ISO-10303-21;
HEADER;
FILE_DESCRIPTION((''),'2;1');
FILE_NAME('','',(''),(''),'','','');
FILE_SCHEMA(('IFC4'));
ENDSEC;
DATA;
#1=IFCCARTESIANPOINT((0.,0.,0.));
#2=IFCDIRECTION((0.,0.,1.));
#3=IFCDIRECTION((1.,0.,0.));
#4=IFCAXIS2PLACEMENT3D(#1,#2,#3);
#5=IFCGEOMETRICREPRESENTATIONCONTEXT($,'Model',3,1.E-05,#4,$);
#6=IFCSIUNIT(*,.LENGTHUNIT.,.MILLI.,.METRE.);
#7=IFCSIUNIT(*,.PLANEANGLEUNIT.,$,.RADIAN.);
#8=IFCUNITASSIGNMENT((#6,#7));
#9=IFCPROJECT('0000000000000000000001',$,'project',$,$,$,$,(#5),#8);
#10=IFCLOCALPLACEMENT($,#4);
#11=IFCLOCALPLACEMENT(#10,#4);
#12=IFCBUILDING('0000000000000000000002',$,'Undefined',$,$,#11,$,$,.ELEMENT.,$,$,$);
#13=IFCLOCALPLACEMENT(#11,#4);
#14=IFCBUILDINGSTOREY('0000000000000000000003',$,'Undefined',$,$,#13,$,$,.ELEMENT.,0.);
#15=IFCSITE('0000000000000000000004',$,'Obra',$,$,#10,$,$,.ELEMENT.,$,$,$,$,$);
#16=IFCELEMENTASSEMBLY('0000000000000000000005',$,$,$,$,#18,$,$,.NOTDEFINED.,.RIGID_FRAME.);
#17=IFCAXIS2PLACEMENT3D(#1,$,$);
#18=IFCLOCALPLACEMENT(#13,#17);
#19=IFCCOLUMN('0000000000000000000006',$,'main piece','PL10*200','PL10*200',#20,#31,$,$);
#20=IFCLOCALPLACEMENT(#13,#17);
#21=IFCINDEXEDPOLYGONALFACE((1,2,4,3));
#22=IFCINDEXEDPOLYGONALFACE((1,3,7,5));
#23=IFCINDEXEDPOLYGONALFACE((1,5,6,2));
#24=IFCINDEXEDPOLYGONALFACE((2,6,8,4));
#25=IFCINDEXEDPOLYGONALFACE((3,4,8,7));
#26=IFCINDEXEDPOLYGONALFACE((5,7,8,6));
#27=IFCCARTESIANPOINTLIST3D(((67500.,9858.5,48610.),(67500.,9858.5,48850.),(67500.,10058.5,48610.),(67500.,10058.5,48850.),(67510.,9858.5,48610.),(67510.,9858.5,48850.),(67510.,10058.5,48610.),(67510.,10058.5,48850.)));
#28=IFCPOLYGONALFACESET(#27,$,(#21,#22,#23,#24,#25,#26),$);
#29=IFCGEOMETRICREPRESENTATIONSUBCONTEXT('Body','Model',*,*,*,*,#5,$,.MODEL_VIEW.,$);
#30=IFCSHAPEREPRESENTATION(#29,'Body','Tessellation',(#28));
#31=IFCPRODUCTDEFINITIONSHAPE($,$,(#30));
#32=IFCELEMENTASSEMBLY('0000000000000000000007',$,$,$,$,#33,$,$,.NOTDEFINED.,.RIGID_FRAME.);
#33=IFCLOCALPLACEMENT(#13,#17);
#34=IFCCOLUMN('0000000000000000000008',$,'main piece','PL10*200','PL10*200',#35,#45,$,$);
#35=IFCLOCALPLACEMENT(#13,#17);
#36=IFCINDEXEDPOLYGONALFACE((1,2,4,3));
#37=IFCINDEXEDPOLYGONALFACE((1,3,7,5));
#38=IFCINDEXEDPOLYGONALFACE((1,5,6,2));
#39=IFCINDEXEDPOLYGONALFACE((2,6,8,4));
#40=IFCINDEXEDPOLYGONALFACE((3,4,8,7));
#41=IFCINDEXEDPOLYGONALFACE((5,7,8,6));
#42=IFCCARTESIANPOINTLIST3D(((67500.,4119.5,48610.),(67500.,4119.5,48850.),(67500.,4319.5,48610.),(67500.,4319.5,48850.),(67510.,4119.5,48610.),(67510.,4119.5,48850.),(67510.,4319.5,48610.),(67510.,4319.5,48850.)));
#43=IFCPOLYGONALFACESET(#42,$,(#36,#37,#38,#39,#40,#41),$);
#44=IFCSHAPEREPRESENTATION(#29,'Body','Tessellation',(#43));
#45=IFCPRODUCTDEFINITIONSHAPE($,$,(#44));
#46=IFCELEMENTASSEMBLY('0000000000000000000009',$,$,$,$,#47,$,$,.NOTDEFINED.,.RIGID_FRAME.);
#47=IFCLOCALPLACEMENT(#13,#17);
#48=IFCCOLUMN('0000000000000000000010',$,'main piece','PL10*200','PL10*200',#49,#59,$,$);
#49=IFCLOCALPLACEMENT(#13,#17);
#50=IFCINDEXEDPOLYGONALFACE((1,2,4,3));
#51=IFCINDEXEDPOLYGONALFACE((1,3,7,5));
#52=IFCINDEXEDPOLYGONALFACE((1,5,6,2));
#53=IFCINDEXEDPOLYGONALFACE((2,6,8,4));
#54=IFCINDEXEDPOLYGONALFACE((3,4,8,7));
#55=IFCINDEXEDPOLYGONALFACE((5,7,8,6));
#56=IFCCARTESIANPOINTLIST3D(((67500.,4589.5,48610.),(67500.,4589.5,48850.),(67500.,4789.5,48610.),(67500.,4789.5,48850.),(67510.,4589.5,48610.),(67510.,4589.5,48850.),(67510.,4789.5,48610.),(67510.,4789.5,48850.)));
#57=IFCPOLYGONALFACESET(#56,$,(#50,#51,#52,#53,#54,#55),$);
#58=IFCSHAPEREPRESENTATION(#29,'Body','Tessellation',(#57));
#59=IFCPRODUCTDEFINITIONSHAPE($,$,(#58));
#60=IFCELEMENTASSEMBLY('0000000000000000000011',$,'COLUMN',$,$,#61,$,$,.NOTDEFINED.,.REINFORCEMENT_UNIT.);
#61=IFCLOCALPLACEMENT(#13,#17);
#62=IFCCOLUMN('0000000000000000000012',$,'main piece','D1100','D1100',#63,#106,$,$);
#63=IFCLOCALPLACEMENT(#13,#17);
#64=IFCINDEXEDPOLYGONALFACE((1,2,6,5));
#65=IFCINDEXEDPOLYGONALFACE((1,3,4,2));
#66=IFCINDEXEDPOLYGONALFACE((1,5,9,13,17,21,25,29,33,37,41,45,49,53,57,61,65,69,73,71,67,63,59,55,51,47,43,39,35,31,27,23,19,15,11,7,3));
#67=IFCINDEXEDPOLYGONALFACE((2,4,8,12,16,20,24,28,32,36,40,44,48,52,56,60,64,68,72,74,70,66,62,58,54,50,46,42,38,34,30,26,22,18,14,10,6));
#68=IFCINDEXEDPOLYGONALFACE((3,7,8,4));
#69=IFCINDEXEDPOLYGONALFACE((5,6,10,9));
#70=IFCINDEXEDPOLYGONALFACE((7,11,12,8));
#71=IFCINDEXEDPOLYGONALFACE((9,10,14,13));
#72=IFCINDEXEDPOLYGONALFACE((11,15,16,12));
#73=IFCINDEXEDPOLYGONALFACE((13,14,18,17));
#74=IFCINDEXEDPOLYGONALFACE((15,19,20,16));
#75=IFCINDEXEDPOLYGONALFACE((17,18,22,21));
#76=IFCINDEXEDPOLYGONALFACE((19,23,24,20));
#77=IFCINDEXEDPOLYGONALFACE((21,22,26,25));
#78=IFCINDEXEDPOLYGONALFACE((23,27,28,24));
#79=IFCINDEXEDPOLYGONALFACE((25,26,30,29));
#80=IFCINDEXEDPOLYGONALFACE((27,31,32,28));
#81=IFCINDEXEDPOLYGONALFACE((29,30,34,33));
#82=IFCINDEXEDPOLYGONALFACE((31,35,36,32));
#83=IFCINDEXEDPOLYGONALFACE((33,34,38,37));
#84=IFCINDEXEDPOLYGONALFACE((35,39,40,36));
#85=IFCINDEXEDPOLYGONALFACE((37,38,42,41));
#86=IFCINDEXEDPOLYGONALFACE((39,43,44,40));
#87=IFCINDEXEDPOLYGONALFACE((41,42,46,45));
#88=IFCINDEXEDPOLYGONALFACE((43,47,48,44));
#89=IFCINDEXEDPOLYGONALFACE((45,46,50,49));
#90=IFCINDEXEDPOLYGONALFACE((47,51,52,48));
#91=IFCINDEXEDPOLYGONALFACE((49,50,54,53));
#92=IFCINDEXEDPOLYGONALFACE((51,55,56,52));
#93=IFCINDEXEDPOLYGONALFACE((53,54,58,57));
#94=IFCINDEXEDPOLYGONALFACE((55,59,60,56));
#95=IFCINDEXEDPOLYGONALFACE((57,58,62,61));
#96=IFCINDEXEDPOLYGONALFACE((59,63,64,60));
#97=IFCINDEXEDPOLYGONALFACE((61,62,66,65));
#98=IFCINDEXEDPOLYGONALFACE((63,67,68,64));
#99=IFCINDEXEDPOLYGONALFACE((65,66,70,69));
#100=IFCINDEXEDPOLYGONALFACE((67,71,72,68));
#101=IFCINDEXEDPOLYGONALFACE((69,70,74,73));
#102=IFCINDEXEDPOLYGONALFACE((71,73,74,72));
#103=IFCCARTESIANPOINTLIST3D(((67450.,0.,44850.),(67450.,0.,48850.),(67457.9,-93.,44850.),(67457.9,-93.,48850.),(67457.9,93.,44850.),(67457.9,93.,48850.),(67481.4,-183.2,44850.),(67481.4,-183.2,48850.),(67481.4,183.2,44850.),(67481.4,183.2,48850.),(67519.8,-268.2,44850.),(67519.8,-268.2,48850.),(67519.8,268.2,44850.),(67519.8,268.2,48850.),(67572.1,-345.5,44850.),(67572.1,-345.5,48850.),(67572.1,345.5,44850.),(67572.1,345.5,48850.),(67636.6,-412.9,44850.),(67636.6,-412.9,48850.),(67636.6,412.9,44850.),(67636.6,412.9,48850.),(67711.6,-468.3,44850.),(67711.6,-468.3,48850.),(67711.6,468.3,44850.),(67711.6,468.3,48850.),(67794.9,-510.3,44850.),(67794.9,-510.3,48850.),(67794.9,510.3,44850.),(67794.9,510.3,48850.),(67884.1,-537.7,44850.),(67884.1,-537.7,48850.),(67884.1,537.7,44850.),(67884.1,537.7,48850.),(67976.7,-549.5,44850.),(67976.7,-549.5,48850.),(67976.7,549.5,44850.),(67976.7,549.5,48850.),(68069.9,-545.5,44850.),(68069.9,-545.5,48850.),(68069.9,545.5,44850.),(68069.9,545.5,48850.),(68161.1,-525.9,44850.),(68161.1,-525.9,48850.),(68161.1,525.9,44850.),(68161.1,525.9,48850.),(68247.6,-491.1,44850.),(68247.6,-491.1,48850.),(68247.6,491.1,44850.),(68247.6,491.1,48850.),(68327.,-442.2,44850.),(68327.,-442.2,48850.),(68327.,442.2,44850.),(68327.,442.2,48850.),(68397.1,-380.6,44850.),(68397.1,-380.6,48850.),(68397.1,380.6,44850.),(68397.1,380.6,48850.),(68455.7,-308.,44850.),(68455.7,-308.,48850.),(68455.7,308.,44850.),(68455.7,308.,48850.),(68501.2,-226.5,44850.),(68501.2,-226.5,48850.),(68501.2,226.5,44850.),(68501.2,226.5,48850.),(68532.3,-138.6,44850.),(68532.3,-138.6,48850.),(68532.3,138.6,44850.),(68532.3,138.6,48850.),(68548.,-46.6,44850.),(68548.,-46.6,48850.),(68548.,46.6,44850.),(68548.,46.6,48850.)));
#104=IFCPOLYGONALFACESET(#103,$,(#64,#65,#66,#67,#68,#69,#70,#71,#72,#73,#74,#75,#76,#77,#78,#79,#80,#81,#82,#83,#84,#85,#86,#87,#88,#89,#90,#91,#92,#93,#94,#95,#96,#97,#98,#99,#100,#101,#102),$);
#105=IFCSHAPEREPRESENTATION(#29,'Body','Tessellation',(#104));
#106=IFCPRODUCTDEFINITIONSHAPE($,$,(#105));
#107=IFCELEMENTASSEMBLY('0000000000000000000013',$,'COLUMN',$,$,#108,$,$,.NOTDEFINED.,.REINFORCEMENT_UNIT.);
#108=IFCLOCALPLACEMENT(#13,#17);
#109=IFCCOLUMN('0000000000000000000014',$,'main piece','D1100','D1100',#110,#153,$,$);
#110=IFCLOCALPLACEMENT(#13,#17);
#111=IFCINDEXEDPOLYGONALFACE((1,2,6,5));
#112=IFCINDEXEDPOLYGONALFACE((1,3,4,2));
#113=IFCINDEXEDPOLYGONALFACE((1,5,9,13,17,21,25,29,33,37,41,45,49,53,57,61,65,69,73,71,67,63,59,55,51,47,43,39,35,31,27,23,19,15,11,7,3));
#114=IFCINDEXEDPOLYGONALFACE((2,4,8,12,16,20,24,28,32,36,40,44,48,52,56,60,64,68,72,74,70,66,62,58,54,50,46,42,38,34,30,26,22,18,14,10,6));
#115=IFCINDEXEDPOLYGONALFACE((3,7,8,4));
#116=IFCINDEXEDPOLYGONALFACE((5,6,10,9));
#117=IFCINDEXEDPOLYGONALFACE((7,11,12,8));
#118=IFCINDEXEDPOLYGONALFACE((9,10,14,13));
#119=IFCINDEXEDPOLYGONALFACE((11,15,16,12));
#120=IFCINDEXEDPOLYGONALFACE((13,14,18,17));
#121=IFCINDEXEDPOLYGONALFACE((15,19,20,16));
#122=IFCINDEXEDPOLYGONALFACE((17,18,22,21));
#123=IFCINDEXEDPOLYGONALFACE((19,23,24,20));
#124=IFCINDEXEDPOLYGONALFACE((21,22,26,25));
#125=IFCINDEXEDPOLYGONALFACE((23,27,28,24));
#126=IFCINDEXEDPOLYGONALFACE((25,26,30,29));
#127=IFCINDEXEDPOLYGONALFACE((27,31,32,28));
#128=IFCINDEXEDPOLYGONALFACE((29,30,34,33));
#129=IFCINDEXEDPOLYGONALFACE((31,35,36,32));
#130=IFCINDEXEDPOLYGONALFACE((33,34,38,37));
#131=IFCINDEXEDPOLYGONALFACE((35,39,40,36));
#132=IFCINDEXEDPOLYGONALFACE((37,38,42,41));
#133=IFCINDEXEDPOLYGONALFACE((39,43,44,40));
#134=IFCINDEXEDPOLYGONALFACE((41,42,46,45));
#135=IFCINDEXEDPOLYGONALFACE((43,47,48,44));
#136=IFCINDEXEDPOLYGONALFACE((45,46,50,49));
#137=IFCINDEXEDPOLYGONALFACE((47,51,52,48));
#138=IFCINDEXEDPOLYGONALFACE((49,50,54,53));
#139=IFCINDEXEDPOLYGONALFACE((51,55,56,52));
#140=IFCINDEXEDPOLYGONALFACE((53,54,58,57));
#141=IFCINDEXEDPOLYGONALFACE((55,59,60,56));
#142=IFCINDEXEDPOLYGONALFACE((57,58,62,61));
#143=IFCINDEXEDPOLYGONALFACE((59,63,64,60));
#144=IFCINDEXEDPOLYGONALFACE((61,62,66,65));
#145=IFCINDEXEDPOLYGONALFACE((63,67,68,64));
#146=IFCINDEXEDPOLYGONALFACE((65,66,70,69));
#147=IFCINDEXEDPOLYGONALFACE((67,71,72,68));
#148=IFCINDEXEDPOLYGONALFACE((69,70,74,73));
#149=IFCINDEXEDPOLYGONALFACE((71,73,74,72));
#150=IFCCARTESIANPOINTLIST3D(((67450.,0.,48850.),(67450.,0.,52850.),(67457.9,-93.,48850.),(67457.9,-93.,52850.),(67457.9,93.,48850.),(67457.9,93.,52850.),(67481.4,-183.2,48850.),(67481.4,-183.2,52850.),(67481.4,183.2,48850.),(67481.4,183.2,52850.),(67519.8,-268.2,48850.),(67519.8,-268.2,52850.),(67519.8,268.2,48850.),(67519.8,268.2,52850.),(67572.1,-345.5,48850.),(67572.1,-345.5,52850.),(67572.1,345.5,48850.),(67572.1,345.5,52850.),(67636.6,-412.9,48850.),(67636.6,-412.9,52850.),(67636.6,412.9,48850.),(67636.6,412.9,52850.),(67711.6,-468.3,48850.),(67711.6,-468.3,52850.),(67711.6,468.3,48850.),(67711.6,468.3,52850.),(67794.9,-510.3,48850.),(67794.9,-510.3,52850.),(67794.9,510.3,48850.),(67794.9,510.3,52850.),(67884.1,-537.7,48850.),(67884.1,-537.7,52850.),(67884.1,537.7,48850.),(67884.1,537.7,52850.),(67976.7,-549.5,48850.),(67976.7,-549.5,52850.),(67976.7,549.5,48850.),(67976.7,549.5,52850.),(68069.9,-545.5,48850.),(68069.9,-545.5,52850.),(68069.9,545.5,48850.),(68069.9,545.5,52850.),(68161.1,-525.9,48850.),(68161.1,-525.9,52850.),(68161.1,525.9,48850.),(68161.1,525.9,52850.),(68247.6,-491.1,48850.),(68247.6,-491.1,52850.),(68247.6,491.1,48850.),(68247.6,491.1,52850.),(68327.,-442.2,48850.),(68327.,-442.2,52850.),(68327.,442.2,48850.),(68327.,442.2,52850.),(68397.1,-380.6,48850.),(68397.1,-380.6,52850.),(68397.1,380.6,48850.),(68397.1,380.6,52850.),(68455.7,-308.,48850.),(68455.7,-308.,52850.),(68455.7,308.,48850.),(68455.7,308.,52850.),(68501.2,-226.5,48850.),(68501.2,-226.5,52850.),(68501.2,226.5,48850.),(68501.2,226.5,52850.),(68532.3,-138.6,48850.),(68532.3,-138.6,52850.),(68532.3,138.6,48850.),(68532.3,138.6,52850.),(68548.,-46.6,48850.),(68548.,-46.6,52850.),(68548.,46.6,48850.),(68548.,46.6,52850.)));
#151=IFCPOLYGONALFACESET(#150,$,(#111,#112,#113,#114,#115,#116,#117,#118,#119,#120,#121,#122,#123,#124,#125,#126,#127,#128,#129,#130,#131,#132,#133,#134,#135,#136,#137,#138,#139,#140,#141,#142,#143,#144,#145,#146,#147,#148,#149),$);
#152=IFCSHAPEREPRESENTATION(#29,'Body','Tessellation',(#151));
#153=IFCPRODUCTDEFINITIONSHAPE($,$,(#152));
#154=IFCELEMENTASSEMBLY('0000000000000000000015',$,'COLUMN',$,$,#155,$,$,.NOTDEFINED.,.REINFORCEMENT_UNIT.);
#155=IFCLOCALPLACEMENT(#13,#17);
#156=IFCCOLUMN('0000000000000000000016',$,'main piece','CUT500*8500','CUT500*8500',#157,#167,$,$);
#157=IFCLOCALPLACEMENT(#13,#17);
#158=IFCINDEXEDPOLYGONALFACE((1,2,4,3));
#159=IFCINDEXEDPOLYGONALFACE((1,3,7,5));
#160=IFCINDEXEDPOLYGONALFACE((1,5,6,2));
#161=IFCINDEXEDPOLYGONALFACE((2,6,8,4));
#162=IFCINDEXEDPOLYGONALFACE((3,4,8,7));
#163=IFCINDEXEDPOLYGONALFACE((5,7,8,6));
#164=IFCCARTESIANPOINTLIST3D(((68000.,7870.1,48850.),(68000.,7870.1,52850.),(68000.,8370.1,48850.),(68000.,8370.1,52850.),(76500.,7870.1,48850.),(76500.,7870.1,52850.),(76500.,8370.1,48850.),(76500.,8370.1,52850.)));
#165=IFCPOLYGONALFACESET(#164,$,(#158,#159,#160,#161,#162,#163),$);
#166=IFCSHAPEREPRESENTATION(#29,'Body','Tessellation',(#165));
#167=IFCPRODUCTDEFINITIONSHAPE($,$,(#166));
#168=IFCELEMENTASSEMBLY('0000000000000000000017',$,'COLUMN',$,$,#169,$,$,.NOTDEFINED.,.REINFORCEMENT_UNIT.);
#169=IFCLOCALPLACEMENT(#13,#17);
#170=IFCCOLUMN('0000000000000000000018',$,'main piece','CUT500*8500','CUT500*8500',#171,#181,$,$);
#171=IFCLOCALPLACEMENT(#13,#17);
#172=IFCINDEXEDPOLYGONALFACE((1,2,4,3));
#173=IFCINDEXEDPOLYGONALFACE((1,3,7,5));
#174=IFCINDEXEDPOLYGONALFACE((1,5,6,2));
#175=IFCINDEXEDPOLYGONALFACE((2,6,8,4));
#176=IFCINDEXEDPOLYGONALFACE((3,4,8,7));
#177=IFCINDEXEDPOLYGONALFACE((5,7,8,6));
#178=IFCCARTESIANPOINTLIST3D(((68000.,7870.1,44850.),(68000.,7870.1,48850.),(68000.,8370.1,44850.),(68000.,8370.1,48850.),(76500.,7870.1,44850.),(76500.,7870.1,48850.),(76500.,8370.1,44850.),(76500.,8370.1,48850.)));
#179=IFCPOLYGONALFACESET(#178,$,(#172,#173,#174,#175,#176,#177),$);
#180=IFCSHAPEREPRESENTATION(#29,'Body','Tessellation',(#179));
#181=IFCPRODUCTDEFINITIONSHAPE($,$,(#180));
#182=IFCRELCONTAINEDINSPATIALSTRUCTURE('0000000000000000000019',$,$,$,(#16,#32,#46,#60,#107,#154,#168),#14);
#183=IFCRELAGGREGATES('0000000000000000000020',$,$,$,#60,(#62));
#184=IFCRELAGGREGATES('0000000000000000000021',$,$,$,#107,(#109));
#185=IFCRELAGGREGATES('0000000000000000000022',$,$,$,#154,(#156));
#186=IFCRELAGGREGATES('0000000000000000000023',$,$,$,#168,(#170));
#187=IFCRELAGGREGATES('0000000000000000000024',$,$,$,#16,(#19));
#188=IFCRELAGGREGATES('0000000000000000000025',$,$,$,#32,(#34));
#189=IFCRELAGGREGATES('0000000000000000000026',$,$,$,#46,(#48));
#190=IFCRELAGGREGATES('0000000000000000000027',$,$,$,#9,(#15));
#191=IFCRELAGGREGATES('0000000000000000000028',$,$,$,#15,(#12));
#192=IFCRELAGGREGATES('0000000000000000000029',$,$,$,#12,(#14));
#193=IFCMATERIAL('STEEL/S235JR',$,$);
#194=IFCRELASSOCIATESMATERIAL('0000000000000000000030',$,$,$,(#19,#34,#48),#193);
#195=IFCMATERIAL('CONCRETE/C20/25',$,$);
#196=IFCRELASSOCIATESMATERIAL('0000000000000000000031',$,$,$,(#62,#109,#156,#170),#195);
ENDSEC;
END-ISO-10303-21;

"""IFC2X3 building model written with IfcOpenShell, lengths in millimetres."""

from ifc_helpers import new_model, si_unit, frame, origin_with_axes, origin_2d_with_axis, place, context, subcontext, project, spatial, rectangle, circle, extrude, material, element, aggregate, save


model = new_model("IFC2X3")

# Units and contexts
model_context = context("Model", 3, precision=1e-05, world=origin_with_axes())
body_context = subcontext(model_context, "Body", "Model", "MODEL_VIEW")
ifc_project = project(units=[si_unit("LENGTHUNIT", "METRE", prefix="MILLI"), si_unit("PLANEANGLEUNIT", "RADIAN")], contexts=[model_context])

# Site, building, storey
site_placement = place(None, origin_with_axes())
site = spatial("IfcSite", under=ifc_project, at=site_placement, Name="Obra", CompositionType="ELEMENT")
building_placement = place(site_placement, origin_with_axes())
building = spatial("IfcBuilding", under=site, at=building_placement, Name="Undefined", CompositionType="ELEMENT")
storey_placement = place(building_placement, origin_with_axes())
storey = spatial("IfcBuildingStorey", under=building, at=storey_placement, Name="Undefined", CompositionType="ELEMENT", Elevation=0.0)

# Element assemblies, columns
assembly_1_placement = place(storey_placement, origin_with_axes())
assembly_1 = element("IfcElementAssembly", 1, at=assembly_1_placement, inside=storey, AssemblyPlace="NOTDEFINED", PredefinedType="RIGID_FRAME")
ifc_material_1 = material(Name="STEEL/S235JR")
column_1_placement = place(assembly_1_placement, frame((67505.0, 9958.5, 48610.0), z_axis=(0.0, 0.0, 1.0), x_axis=(0.0, 1.0, 0.0)))
column_1 = element("IfcColumn", 2, at=column_1_placement, material=ifc_material_1, Name="main piece", Description="PL10*200", ObjectType="PL10*200", context=body_context, shape_type="SweptSolid", body=[
    extrude(rectangle(XDim=10.0, YDim=200.0, at=origin_2d_with_axis()), frame((0.0, 0.0, 240.0), z_axis=(0.0, 0.0, -1.0), x_axis=(0.0, 1.0, 0.0)), (0.0, 0.0, 1.0), 240.0),
])
assembly_2_placement = place(storey_placement, origin_with_axes())
assembly_2 = element("IfcElementAssembly", 3, at=assembly_2_placement, inside=storey, AssemblyPlace="NOTDEFINED", PredefinedType="RIGID_FRAME")
column_2_placement = place(assembly_2_placement, frame((67505.0, 4219.5, 48610.0), z_axis=(0.0, 0.0, 1.0), x_axis=(0.0, 1.0, 0.0)))
column_2 = element("IfcColumn", 4, at=column_2_placement, material=ifc_material_1, Name="main piece", Description="PL10*200", ObjectType="PL10*200", context=body_context, shape_type="SweptSolid", body=[
    extrude(rectangle(XDim=10.0, YDim=200.0, at=origin_2d_with_axis()), frame((0.0, 0.0, 240.0), z_axis=(0.0, 0.0, -1.0), x_axis=(0.0, 1.0, 0.0)), (0.0, 0.0, 1.0), 240.0),
])
assembly_3_placement = place(storey_placement, origin_with_axes())
assembly_3 = element("IfcElementAssembly", 5, at=assembly_3_placement, inside=storey, AssemblyPlace="NOTDEFINED", PredefinedType="RIGID_FRAME")
column_3_placement = place(assembly_3_placement, frame((67505.0, 4689.5, 48610.0), z_axis=(0.0, 0.0, 1.0), x_axis=(0.0, 1.0, 0.0)))
column_3 = element("IfcColumn", 6, at=column_3_placement, material=ifc_material_1, Name="main piece", Description="PL10*200", ObjectType="PL10*200", context=body_context, shape_type="SweptSolid", body=[
    extrude(rectangle(XDim=10.0, YDim=200.0, at=origin_2d_with_axis()), frame((0.0, 0.0, 240.0), z_axis=(0.0, 0.0, -1.0), x_axis=(0.0, 1.0, 0.0)), (0.0, 0.0, 1.0), 240.0),
])
assembly_4_placement = place(storey_placement, origin_with_axes())
assembly_4 = element("IfcElementAssembly", 7, at=assembly_4_placement, inside=storey, Name="COLUMN", AssemblyPlace="NOTDEFINED", PredefinedType="REINFORCEMENT_UNIT")
ifc_material_2 = material(Name="CONCRETE/C20/25")
column_4_placement = place(assembly_4_placement, frame((68000.0, 0.0, 44850.0), z_axis=(0.0, 0.0, 1.0), x_axis=(0.0, 1.0, 0.0)))
column_4 = element("IfcColumn", 8, at=column_4_placement, material=ifc_material_2, Name="main piece", Description="D1100", ObjectType="D1100", context=body_context, shape_type="SweptSolid", body=[
    extrude(circle(Radius=550.0, at=origin_2d_with_axis()), frame((0.0, 0.0, 4000.0), z_axis=(0.0, 0.0, -1.0), x_axis=(0.0, 1.0, 0.0)), (0.0, 0.0, 1.0), 4000.0),
])
aggregate(assembly_4, [column_4])
assembly_5_placement = place(storey_placement, origin_with_axes())
assembly_5 = element("IfcElementAssembly", 9, at=assembly_5_placement, inside=storey, Name="COLUMN", AssemblyPlace="NOTDEFINED", PredefinedType="REINFORCEMENT_UNIT")
column_5_placement = place(assembly_5_placement, frame((68000.0, 0.0, 48850.0), z_axis=(0.0, 0.0, 1.0), x_axis=(0.0, 1.0, 0.0)))
column_5 = element("IfcColumn", 10, at=column_5_placement, material=ifc_material_2, Name="main piece", Description="D1100", ObjectType="D1100", context=body_context, shape_type="SweptSolid", body=[
    extrude(circle(Radius=550.0, at=origin_2d_with_axis()), frame((0.0, 0.0, 4000.0), z_axis=(0.0, 0.0, -1.0), x_axis=(0.0, 1.0, 0.0)), (0.0, 0.0, 1.0), 4000.0),
])
aggregate(assembly_5, [column_5])
assembly_6_placement = place(storey_placement, origin_with_axes())
assembly_6 = element("IfcElementAssembly", 11, at=assembly_6_placement, inside=storey, Name="COLUMN", AssemblyPlace="NOTDEFINED", PredefinedType="REINFORCEMENT_UNIT")
column_6_placement = place(assembly_6_placement, frame((72250.0, 8120.1, 48850.0), z_axis=(0.0, 0.0, 1.0), x_axis=(-1.0, 0.0, 0.0)))
column_6 = element("IfcColumn", 12, at=column_6_placement, material=ifc_material_2, Name="main piece", Description="CUT500*8500", ObjectType="CUT500*8500", context=body_context, shape_type="SweptSolid", body=[
    extrude(rectangle(XDim=500.0, YDim=8500.0, at=origin_2d_with_axis()), frame((0.0, 0.0, 4000.0), z_axis=(0.0, 0.0, -1.0), x_axis=(0.0, 1.0, 0.0)), (0.0, 0.0, 1.0), 4000.0),
])
aggregate(assembly_6, [column_6])
assembly_7_placement = place(storey_placement, origin_with_axes())
assembly_7 = element("IfcElementAssembly", 13, at=assembly_7_placement, inside=storey, Name="COLUMN", AssemblyPlace="NOTDEFINED", PredefinedType="REINFORCEMENT_UNIT")
column_7_placement = place(assembly_7_placement, frame((72250.0, 8120.1, 44850.0), z_axis=(0.0, 0.0, 1.0), x_axis=(-1.0, 0.0, 0.0)))
column_7 = element("IfcColumn", 14, at=column_7_placement, material=ifc_material_2, Name="main piece", Description="CUT500*8500", ObjectType="CUT500*8500", context=body_context, shape_type="SweptSolid", body=[
    extrude(rectangle(XDim=500.0, YDim=8500.0, at=origin_2d_with_axis()), frame((0.0, 0.0, 4000.0), z_axis=(0.0, 0.0, -1.0), x_axis=(0.0, 1.0, 0.0)), (0.0, 0.0, 1.0), 4000.0),
])
aggregate(assembly_7, [column_7])

aggregate(assembly_1, [column_1])
aggregate(assembly_2, [column_2])
aggregate(assembly_3, [column_3])

save(model, "model.ifc")
